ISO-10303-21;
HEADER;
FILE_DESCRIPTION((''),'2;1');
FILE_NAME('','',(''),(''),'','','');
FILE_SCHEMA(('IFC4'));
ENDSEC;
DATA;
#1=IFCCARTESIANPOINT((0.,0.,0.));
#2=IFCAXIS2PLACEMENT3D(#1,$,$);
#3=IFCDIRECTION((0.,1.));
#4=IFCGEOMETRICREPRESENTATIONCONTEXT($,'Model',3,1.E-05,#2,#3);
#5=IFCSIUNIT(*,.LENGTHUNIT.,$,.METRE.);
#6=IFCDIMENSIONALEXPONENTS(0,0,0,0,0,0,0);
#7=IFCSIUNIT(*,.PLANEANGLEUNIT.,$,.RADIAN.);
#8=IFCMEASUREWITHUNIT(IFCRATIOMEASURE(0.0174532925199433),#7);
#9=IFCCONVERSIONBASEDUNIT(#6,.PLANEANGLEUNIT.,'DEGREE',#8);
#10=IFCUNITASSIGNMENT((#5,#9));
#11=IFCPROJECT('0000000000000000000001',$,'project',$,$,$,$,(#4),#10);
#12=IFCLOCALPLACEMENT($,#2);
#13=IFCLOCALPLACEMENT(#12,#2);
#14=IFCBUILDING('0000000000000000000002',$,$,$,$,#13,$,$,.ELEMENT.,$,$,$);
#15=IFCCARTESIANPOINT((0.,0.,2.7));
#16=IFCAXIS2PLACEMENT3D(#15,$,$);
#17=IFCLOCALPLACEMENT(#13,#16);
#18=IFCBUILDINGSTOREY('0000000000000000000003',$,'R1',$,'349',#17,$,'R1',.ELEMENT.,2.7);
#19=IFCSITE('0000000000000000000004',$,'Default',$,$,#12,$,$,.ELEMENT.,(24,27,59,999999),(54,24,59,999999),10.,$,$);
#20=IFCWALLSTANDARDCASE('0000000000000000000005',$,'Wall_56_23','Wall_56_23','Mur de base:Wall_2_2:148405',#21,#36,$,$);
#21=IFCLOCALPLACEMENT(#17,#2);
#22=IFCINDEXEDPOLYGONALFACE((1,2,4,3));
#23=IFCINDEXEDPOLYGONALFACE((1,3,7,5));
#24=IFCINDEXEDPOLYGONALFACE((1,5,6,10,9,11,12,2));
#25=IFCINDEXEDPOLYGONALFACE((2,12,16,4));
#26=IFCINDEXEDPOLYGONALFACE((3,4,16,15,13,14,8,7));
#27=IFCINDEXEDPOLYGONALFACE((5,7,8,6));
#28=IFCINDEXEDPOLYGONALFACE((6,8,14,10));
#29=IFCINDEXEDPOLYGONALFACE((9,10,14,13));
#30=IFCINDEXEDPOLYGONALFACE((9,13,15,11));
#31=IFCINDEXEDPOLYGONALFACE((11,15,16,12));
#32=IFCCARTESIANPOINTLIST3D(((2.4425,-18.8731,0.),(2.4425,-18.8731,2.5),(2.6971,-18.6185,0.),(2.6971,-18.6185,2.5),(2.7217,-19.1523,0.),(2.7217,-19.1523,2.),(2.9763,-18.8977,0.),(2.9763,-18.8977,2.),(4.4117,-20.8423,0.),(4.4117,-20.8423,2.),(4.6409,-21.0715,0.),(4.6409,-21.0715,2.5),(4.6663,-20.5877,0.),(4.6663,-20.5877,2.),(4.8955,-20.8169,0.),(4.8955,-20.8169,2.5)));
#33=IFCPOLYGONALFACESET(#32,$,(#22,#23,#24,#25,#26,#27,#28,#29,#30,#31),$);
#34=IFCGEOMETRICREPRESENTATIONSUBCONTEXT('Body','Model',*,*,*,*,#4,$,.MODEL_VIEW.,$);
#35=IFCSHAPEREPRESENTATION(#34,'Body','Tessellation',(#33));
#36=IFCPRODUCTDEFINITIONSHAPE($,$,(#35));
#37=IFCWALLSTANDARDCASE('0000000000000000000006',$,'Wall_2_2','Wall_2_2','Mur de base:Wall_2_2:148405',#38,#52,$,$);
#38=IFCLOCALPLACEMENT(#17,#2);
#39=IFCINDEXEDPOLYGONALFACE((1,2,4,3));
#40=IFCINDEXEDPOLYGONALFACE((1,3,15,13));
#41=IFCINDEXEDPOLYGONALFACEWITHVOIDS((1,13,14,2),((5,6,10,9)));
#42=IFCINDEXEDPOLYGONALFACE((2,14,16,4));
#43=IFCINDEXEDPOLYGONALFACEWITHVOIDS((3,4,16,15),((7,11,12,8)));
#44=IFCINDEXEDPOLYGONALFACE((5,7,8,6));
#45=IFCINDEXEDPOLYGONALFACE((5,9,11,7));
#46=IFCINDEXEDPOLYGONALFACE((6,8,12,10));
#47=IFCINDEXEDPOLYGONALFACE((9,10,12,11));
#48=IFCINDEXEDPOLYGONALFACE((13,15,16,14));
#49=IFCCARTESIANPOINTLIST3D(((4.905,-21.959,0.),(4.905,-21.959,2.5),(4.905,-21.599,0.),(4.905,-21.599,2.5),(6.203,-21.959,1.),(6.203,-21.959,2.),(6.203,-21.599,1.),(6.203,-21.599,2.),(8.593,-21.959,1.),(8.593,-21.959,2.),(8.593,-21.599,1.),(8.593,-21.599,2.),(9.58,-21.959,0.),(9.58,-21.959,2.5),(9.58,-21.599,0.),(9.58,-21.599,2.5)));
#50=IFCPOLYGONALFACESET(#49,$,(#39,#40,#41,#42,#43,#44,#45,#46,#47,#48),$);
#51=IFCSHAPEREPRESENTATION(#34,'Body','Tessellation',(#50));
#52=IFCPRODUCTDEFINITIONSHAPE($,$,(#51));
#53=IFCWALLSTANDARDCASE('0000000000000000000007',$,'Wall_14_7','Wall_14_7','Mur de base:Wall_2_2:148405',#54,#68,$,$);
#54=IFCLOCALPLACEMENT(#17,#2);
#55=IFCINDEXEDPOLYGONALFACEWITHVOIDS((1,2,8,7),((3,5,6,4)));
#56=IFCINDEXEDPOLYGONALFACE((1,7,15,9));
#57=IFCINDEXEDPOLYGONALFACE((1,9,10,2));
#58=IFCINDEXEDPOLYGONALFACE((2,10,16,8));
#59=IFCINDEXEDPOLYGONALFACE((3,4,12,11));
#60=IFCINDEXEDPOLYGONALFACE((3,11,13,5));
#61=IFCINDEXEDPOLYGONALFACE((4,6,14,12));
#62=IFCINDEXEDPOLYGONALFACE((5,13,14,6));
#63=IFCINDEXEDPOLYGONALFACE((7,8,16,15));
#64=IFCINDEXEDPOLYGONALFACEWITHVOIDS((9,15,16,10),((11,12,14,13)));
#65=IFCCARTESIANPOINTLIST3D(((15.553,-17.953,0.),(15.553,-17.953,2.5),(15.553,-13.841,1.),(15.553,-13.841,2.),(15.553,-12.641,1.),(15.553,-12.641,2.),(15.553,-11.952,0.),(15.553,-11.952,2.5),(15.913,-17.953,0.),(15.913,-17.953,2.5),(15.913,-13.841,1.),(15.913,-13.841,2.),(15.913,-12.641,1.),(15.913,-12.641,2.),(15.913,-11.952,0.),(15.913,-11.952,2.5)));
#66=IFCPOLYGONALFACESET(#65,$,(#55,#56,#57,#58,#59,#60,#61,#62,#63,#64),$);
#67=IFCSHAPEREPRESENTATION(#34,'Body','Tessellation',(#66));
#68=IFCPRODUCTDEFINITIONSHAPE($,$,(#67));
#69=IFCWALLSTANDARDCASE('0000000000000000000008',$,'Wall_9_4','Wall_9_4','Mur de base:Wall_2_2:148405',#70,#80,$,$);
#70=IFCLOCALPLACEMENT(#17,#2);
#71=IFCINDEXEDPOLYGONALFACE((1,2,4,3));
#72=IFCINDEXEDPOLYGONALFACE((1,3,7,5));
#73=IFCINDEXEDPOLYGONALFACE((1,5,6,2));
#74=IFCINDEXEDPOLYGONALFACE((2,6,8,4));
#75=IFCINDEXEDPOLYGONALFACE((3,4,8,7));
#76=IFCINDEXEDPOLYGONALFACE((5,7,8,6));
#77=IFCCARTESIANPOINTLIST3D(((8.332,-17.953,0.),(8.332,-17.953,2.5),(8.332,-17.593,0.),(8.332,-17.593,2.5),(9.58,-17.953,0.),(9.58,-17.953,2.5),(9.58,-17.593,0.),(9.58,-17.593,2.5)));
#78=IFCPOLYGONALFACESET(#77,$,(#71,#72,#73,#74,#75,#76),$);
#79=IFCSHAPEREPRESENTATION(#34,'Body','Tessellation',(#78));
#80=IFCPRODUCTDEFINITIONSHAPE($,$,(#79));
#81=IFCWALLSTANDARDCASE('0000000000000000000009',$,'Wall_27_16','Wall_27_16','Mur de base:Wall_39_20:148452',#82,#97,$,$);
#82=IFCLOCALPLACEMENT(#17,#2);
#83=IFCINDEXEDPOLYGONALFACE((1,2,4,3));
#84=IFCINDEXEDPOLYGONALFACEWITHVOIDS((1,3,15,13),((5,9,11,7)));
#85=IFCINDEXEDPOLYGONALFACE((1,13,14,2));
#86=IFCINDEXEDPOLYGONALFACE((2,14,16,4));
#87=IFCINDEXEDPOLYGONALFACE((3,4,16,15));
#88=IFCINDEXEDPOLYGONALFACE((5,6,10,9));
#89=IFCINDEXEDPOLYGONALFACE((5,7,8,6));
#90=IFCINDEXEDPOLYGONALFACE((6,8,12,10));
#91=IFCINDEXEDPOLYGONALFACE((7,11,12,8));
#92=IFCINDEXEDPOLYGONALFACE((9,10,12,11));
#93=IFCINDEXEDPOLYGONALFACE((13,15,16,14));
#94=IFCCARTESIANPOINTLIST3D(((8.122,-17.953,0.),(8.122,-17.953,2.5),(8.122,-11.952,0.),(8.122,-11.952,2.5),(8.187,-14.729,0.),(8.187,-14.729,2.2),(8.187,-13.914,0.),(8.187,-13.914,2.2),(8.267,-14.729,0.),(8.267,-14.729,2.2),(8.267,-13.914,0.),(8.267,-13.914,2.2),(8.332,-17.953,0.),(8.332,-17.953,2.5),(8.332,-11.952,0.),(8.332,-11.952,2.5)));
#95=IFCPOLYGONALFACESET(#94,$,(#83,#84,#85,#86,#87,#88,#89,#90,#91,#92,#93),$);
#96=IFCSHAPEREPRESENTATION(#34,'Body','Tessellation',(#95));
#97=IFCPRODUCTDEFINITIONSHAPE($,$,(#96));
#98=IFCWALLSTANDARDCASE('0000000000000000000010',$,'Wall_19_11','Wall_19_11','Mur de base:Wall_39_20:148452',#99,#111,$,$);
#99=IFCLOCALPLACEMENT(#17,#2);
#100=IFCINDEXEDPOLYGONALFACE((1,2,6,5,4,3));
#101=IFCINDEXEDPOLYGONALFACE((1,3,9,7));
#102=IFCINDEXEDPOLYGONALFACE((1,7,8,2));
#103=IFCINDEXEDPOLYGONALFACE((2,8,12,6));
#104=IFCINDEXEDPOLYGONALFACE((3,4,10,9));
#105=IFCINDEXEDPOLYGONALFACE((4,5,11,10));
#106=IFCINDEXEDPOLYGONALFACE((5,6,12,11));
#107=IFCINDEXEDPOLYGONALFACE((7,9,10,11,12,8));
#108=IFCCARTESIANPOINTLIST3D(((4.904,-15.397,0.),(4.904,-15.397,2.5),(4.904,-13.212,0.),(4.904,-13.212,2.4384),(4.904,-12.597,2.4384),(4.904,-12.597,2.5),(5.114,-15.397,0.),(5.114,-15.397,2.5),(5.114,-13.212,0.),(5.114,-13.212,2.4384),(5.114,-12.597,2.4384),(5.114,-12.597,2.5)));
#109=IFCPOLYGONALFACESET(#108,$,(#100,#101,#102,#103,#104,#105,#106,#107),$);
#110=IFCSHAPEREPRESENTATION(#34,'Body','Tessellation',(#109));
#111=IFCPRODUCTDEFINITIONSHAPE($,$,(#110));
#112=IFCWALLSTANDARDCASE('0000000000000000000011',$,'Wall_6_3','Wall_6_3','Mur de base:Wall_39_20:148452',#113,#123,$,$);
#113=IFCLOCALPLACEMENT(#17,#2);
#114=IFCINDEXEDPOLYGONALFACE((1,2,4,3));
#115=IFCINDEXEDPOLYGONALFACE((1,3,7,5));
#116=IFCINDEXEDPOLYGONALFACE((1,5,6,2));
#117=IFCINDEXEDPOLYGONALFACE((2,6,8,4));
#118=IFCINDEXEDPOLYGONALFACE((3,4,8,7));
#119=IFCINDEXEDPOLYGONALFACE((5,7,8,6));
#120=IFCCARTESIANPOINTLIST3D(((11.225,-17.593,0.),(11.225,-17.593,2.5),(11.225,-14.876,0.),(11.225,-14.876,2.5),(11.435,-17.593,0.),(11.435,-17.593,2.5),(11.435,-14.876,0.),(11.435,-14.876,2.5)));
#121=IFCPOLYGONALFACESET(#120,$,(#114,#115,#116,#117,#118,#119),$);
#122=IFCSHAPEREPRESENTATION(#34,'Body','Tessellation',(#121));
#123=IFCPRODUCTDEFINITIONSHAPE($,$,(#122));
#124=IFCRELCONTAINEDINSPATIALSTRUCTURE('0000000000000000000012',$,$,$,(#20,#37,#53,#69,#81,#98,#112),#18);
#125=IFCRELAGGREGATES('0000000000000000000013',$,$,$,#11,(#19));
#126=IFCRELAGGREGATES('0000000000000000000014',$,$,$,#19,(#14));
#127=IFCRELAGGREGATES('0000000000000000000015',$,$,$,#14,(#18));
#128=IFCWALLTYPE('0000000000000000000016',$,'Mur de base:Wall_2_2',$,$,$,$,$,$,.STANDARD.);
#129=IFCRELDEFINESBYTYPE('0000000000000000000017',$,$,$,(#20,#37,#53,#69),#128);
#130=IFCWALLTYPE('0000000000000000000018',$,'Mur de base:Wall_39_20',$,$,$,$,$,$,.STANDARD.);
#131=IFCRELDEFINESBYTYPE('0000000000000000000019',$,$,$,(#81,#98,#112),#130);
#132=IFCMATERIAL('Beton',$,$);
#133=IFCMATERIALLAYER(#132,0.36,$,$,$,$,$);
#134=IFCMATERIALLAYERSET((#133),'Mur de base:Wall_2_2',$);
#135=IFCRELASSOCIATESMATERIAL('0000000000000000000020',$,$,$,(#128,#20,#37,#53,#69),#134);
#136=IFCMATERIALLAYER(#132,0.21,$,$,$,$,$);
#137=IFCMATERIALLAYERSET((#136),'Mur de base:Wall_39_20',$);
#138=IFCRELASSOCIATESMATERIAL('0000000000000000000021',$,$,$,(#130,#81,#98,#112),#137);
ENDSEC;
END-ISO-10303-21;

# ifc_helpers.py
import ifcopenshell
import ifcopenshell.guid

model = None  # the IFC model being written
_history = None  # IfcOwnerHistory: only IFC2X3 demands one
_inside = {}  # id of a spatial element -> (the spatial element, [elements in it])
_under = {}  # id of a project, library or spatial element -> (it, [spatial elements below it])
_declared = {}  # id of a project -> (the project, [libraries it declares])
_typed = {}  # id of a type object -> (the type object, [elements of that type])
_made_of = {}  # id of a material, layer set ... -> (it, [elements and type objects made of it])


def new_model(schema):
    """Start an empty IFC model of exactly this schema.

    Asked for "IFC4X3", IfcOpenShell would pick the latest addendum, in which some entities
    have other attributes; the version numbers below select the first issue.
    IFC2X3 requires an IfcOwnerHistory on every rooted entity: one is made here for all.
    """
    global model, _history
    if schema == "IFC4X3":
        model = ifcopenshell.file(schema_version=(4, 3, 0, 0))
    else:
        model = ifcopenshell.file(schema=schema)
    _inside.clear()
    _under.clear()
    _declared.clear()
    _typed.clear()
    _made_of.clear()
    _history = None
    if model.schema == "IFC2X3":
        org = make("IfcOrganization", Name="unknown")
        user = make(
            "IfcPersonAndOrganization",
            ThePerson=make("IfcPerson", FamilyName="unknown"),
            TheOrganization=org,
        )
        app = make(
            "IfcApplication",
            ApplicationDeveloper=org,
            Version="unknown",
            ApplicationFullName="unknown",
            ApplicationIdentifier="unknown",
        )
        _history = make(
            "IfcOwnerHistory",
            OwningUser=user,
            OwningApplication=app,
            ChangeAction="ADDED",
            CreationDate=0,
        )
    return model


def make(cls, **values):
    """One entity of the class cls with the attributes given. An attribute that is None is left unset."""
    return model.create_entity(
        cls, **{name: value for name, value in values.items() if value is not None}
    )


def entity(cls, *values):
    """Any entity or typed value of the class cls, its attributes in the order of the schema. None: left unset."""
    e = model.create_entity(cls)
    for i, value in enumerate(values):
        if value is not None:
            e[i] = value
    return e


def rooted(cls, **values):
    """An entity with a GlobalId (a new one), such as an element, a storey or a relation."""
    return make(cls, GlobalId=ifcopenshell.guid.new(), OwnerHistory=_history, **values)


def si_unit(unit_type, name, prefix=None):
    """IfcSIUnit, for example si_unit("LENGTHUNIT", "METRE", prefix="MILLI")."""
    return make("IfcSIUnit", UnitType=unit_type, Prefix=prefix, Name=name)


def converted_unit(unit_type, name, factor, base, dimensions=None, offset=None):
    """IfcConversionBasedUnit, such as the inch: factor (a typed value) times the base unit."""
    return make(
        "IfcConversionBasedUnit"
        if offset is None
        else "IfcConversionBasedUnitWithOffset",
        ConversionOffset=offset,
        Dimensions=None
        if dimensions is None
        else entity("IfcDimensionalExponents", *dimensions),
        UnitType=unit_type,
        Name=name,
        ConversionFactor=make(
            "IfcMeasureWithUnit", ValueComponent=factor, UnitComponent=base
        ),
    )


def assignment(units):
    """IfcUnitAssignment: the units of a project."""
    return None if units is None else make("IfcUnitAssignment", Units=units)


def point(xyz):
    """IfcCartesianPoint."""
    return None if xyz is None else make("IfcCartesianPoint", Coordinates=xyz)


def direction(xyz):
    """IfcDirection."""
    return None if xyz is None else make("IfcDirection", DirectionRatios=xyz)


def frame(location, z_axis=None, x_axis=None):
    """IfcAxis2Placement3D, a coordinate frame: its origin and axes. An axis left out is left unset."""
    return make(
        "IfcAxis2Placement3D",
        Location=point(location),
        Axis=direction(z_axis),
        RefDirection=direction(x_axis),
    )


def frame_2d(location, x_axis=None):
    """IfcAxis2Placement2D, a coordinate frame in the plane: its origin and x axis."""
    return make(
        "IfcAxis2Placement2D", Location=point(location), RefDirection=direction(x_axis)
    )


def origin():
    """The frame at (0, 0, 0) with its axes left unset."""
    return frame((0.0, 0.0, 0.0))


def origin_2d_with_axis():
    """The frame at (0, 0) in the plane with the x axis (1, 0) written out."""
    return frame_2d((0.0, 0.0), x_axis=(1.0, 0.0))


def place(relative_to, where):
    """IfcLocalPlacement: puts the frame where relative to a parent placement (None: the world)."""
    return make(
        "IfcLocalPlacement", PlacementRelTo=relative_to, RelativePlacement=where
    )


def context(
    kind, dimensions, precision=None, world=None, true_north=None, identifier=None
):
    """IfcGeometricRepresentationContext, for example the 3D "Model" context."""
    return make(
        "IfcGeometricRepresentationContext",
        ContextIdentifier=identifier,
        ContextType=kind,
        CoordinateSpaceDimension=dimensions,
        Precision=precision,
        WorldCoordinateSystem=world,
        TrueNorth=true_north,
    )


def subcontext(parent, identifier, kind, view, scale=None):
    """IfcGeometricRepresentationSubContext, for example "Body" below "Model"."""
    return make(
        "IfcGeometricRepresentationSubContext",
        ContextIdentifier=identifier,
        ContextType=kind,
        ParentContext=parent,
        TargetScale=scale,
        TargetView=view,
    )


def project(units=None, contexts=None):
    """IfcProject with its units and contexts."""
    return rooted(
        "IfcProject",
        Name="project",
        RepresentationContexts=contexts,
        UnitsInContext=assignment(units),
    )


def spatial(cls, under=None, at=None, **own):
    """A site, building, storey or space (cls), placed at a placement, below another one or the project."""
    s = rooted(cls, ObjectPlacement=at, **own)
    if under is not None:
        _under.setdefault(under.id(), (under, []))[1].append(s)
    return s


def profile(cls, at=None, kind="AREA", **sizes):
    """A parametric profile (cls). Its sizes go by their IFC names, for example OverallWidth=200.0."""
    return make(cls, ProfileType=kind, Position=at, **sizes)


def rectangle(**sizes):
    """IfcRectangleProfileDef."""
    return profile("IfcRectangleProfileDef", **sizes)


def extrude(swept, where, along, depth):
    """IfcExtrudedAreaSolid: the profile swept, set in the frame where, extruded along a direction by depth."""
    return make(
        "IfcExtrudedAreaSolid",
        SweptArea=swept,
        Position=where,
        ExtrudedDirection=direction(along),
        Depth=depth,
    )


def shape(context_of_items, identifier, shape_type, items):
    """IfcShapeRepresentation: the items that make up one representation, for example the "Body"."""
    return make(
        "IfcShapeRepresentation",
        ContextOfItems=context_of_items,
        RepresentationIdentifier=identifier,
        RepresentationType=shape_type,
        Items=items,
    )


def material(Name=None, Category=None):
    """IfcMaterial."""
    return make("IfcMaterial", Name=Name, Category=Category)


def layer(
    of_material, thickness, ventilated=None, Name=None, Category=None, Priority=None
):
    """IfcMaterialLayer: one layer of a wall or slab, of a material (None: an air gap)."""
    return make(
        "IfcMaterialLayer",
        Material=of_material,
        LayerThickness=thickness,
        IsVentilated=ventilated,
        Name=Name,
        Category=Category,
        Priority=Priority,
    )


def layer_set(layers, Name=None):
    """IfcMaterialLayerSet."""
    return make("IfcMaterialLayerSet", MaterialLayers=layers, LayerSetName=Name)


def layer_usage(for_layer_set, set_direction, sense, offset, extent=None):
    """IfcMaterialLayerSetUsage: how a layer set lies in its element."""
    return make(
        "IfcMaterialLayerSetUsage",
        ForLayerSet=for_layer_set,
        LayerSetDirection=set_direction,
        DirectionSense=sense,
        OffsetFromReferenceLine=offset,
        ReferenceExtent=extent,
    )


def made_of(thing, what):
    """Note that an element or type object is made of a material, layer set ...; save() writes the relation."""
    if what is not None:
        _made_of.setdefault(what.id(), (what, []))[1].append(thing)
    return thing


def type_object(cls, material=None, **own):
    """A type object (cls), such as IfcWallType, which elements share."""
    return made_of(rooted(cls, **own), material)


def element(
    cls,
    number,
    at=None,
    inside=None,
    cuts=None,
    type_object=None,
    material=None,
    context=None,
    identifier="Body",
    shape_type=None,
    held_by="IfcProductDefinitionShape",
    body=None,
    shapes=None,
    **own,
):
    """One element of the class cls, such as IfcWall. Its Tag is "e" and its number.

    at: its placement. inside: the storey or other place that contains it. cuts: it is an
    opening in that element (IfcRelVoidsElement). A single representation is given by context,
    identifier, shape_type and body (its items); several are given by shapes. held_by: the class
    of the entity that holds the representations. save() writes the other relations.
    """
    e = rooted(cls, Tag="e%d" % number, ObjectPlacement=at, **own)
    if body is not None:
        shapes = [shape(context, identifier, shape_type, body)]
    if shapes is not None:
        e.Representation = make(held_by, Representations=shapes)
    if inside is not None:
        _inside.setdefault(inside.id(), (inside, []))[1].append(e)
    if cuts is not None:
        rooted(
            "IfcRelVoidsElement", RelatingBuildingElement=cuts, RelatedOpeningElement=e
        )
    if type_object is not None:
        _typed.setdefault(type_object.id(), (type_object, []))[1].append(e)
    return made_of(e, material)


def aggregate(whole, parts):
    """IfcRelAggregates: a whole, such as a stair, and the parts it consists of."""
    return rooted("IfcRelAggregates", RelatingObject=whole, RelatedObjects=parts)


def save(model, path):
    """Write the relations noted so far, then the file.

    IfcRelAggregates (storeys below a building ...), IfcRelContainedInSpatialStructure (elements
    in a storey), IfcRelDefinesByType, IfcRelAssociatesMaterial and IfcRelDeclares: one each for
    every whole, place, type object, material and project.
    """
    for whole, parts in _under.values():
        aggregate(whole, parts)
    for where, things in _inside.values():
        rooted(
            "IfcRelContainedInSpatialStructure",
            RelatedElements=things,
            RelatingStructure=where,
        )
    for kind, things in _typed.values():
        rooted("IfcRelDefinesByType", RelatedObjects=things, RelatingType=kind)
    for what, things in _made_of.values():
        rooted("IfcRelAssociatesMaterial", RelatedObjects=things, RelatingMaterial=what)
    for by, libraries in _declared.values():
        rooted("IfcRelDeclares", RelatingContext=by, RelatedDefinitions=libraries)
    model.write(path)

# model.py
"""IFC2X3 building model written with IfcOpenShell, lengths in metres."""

from ifc_helpers import new_model, entity, si_unit, converted_unit, direction, frame, frame_2d, origin, origin_2d_with_axis, place, context, subcontext, project, spatial, rectangle, extrude, material, layer, layer_set, layer_usage, type_object, element, save


model = new_model("IFC2X3")

# Units and contexts
model_context = context("Model", 3, precision=1e-05, world=origin(), true_north=direction((0.0, 1.0)))
body_context = subcontext(model_context, "Body", "Model", "MODEL_VIEW")
ifc_project = project(units=[si_unit("LENGTHUNIT", "METRE"), converted_unit("PLANEANGLEUNIT", "DEGREE", entity("IfcRatioMeasure", 0.0174532925199433), si_unit("PLANEANGLEUNIT", "RADIAN"), dimensions=[0, 0, 0, 0, 0, 0, 0])], contexts=[model_context])

# Site, building, storey
site_placement = place(None, origin())
site = spatial("IfcSite", under=ifc_project, at=site_placement, Name="Default", CompositionType="ELEMENT", RefLatitude=(24, 27, 59, 999999), RefLongitude=(54, 24, 59, 999999), RefElevation=10.0)
building_placement = place(site_placement, origin())
building = spatial("IfcBuilding", under=site, at=building_placement, CompositionType="ELEMENT")
storey_placement = place(building_placement, frame((0.0, 0.0, 2.7)))
storey = spatial("IfcBuildingStorey", under=building, at=storey_placement, Name="R1", ObjectType="349", LongName="R1", CompositionType="ELEMENT", Elevation=2.7)

# Wall, opening
ifc_material_1 = material(Name="Beton")
ifc_layer_1 = layer(ifc_material_1, 0.36)
ifc_layer_set_1 = layer_set([ifc_layer_1], Name="Mur de base:Wall_2_2")
ifc_layer_usage_1 = layer_usage(ifc_layer_set_1, "AXIS2", "NEGATIVE", 0.18)
wall_type_1 = type_object("IfcWallType", Name="Mur de base:Wall_2_2", PredefinedType="STANDARD", material=ifc_layer_set_1)
wall_1_placement = place(storey_placement, frame((2.5698, -18.7458, 0.0), z_axis=(0.0, 0.0, 1.0), x_axis=(0.707107, -0.707107, 0.0)))
wall_1 = element("IfcWallStandardCase", 1, at=wall_1_placement, inside=storey, type_object=wall_type_1, material=ifc_layer_usage_1, Name="Wall_56_23", Description="Wall_56_23", ObjectType="Mur de base:Wall_2_2:148405", context=body_context, shape_type="SweptSolid", body=[
    extrude(rectangle(XDim=3.109, YDim=0.36, at=frame_2d((1.5545, 0.0), x_axis=(-1.0, 0.0))), origin(), (0.0, 0.0, 1.0), 2.5),
])
opening_1_placement = place(wall_1_placement, origin())
element("IfcOpeningElement", 2, at=opening_1_placement, cuts=wall_1, ObjectType="Opening", context=body_context, shape_type="SweptSolid", body=[
    extrude(rectangle(XDim=2.0, YDim=2.39, at=frame_2d((0.0, 0.0), x_axis=(1.0, 0.0))), frame((1.5898, -0.19, 1.0), z_axis=(0.0, 1.0, 0.0), x_axis=(0.0, 0.0, -1.0)), (0.0, 0.0, 1.0), 0.38),
])

# Walls, openings
ifc_layer_usage_2 = layer_usage(ifc_layer_set_1, "AXIS2", "NEGATIVE", 0.18)
wall_2_placement = place(storey_placement, frame((4.905, -21.779, 0.0)))
wall_2 = element("IfcWallStandardCase", 3, at=wall_2_placement, inside=storey, type_object=wall_type_1, material=ifc_layer_usage_2, Name="Wall_2_2", Description="Wall_2_2", ObjectType="Mur de base:Wall_2_2:148405", context=body_context, shape_type="SweptSolid", body=[
    extrude(rectangle(XDim=4.675, YDim=0.36, at=frame_2d((2.3375, 0.0), x_axis=(-1.0, 0.0))), origin(), (0.0, 0.0, 1.0), 2.5),
])
opening_2_placement = place(wall_2_placement, origin())
element("IfcOpeningElement", 4, at=opening_2_placement, cuts=wall_2, ObjectType="Opening", context=body_context, shape_type="SweptSolid", body=[
    extrude(rectangle(XDim=1.0, YDim=2.39, at=origin_2d_with_axis()), frame((2.493, -0.19, 1.5), z_axis=(0.0, 1.0, 0.0), x_axis=(0.0, 0.0, -1.0)), (0.0, 0.0, 1.0), 0.38),
])
ifc_layer_usage_3 = layer_usage(ifc_layer_set_1, "AXIS2", "NEGATIVE", 0.18)
wall_3_placement = place(storey_placement, frame((15.733, -17.953, 0.0), z_axis=(0.0, 0.0, 1.0), x_axis=(0.0, 1.0, 0.0)))
wall_3 = element("IfcWallStandardCase", 5, at=wall_3_placement, inside=storey, type_object=wall_type_1, material=ifc_layer_usage_3, Name="Wall_14_7", Description="Wall_14_7", ObjectType="Mur de base:Wall_2_2:148405", context=body_context, shape_type="SweptSolid", body=[
    extrude(rectangle(XDim=6.001, YDim=0.36, at=frame_2d((3.0005, 0.0), x_axis=(-1.0, 0.0))), origin(), (0.0, 0.0, 1.0), 2.5),
])
opening_3_placement = place(wall_3_placement, origin())
element("IfcOpeningElement", 6, at=opening_3_placement, cuts=wall_3, ObjectType="Opening", context=body_context, shape_type="SweptSolid", body=[
    extrude(rectangle(XDim=1.0, YDim=1.2, at=origin_2d_with_axis()), frame((4.712, -0.19, 1.5), z_axis=(0.0, 1.0, 0.0), x_axis=(0.0, 0.0, -1.0)), (0.0, 0.0, 1.0), 0.38),
])

# Wall
ifc_layer_usage_4 = layer_usage(ifc_layer_set_1, "AXIS2", "NEGATIVE", 0.18)
wall_4_placement = place(storey_placement, frame((8.332, -17.773, 0.0)))
element("IfcWallStandardCase", 7, at=wall_4_placement, inside=storey, type_object=wall_type_1, material=ifc_layer_usage_4, Name="Wall_9_4", Description="Wall_9_4", ObjectType="Mur de base:Wall_2_2:148405", context=body_context, shape_type="SweptSolid", body=[
    extrude(rectangle(XDim=1.248, YDim=0.36, at=frame_2d((0.624, 0.0), x_axis=(-1.0, 0.0))), origin(), (0.0, 0.0, 1.0), 2.5),
])

# Walls, openings
ifc_layer_2 = layer(ifc_material_1, 0.21)
ifc_layer_set_2 = layer_set([ifc_layer_2], Name="Mur de base:Wall_39_20")
ifc_layer_usage_5 = layer_usage(ifc_layer_set_2, "AXIS2", "NEGATIVE", 0.105)
wall_type_2 = type_object("IfcWallType", Name="Mur de base:Wall_39_20", PredefinedType="STANDARD", material=ifc_layer_set_2)
wall_5_placement = place(storey_placement, frame((8.227, -17.953, 0.0), z_axis=(0.0, 0.0, 1.0), x_axis=(0.0, 1.0, 0.0)))
wall_5 = element("IfcWallStandardCase", 8, at=wall_5_placement, inside=storey, type_object=wall_type_2, material=ifc_layer_usage_5, Name="Wall_27_16", Description="Wall_27_16", ObjectType="Mur de base:Wall_39_20:148452", context=body_context, shape_type="SweptSolid", body=[
    extrude(rectangle(XDim=6.001, YDim=0.21, at=frame_2d((3.0005, 0.0), x_axis=(-1.0, 0.0))), origin(), (0.0, 0.0, 1.0), 2.5),
])
opening_4_placement = place(wall_5_placement, origin())
element("IfcOpeningElement", 9, at=opening_4_placement, cuts=wall_5, ObjectType="Recess", context=body_context, shape_type="SweptSolid", body=[
    extrude(rectangle(XDim=2.2, YDim=0.815, at=frame_2d((0.0, 0.0), x_axis=(1.0, 0.0))), frame((3.6315, -0.04, 1.1), z_axis=(0.0, 1.0, 0.0), x_axis=(0.0, 0.0, -1.0)), (0.0, 0.0, 1.0), 0.08),
])
ifc_layer_usage_6 = layer_usage(ifc_layer_set_2, "AXIS2", "NEGATIVE", 0.105)
wall_6_placement = place(storey_placement, frame((5.009, -15.397, 0.0), z_axis=(0.0, 0.0, 1.0), x_axis=(0.0, 1.0, 0.0)))
wall_6 = element("IfcWallStandardCase", 10, at=wall_6_placement, inside=storey, type_object=wall_type_2, material=ifc_layer_usage_6, Name="Wall_19_11", Description="Wall_19_11", ObjectType="Mur de base:Wall_39_20:148452", context=body_context, shape_type="SweptSolid", body=[
    extrude(rectangle(XDim=2.8, YDim=0.21, at=frame_2d((1.4, 0.0), x_axis=(-1.0, 0.0))), origin(), (0.0, 0.0, 1.0), 2.5),
])
opening_5_placement = place(wall_6_placement, origin())
element("IfcOpeningElement", 11, at=opening_5_placement, cuts=wall_6, ObjectType="Opening", context=body_context, shape_type="SweptSolid", body=[
    extrude(rectangle(XDim=2.4384, YDim=1.44, at=origin_2d_with_axis()), frame((2.905, -0.105, 1.2192), z_axis=(0.0, 1.0, 0.0), x_axis=(0.0, 0.0, -1.0)), (0.0, 0.0, 1.0), 0.21),
])

# Wall
ifc_layer_usage_7 = layer_usage(ifc_layer_set_2, "AXIS2", "NEGATIVE", 0.105)
wall_7_placement = place(storey_placement, frame((11.33, -17.593, 0.0), z_axis=(0.0, 0.0, 1.0), x_axis=(0.0, 1.0, 0.0)))
element("IfcWallStandardCase", 12, at=wall_7_placement, inside=storey, type_object=wall_type_2, material=ifc_layer_usage_7, Name="Wall_6_3", Description="Wall_6_3", ObjectType="Mur de base:Wall_39_20:148452", context=body_context, shape_type="SweptSolid", body=[
    extrude(rectangle(XDim=2.717, YDim=0.21, at=frame_2d((1.3585, 0.0), x_axis=(-1.0, 0.0))), origin(), (0.0, 0.0, 1.0), 2.5),
])

save(model, "model.ifc")
